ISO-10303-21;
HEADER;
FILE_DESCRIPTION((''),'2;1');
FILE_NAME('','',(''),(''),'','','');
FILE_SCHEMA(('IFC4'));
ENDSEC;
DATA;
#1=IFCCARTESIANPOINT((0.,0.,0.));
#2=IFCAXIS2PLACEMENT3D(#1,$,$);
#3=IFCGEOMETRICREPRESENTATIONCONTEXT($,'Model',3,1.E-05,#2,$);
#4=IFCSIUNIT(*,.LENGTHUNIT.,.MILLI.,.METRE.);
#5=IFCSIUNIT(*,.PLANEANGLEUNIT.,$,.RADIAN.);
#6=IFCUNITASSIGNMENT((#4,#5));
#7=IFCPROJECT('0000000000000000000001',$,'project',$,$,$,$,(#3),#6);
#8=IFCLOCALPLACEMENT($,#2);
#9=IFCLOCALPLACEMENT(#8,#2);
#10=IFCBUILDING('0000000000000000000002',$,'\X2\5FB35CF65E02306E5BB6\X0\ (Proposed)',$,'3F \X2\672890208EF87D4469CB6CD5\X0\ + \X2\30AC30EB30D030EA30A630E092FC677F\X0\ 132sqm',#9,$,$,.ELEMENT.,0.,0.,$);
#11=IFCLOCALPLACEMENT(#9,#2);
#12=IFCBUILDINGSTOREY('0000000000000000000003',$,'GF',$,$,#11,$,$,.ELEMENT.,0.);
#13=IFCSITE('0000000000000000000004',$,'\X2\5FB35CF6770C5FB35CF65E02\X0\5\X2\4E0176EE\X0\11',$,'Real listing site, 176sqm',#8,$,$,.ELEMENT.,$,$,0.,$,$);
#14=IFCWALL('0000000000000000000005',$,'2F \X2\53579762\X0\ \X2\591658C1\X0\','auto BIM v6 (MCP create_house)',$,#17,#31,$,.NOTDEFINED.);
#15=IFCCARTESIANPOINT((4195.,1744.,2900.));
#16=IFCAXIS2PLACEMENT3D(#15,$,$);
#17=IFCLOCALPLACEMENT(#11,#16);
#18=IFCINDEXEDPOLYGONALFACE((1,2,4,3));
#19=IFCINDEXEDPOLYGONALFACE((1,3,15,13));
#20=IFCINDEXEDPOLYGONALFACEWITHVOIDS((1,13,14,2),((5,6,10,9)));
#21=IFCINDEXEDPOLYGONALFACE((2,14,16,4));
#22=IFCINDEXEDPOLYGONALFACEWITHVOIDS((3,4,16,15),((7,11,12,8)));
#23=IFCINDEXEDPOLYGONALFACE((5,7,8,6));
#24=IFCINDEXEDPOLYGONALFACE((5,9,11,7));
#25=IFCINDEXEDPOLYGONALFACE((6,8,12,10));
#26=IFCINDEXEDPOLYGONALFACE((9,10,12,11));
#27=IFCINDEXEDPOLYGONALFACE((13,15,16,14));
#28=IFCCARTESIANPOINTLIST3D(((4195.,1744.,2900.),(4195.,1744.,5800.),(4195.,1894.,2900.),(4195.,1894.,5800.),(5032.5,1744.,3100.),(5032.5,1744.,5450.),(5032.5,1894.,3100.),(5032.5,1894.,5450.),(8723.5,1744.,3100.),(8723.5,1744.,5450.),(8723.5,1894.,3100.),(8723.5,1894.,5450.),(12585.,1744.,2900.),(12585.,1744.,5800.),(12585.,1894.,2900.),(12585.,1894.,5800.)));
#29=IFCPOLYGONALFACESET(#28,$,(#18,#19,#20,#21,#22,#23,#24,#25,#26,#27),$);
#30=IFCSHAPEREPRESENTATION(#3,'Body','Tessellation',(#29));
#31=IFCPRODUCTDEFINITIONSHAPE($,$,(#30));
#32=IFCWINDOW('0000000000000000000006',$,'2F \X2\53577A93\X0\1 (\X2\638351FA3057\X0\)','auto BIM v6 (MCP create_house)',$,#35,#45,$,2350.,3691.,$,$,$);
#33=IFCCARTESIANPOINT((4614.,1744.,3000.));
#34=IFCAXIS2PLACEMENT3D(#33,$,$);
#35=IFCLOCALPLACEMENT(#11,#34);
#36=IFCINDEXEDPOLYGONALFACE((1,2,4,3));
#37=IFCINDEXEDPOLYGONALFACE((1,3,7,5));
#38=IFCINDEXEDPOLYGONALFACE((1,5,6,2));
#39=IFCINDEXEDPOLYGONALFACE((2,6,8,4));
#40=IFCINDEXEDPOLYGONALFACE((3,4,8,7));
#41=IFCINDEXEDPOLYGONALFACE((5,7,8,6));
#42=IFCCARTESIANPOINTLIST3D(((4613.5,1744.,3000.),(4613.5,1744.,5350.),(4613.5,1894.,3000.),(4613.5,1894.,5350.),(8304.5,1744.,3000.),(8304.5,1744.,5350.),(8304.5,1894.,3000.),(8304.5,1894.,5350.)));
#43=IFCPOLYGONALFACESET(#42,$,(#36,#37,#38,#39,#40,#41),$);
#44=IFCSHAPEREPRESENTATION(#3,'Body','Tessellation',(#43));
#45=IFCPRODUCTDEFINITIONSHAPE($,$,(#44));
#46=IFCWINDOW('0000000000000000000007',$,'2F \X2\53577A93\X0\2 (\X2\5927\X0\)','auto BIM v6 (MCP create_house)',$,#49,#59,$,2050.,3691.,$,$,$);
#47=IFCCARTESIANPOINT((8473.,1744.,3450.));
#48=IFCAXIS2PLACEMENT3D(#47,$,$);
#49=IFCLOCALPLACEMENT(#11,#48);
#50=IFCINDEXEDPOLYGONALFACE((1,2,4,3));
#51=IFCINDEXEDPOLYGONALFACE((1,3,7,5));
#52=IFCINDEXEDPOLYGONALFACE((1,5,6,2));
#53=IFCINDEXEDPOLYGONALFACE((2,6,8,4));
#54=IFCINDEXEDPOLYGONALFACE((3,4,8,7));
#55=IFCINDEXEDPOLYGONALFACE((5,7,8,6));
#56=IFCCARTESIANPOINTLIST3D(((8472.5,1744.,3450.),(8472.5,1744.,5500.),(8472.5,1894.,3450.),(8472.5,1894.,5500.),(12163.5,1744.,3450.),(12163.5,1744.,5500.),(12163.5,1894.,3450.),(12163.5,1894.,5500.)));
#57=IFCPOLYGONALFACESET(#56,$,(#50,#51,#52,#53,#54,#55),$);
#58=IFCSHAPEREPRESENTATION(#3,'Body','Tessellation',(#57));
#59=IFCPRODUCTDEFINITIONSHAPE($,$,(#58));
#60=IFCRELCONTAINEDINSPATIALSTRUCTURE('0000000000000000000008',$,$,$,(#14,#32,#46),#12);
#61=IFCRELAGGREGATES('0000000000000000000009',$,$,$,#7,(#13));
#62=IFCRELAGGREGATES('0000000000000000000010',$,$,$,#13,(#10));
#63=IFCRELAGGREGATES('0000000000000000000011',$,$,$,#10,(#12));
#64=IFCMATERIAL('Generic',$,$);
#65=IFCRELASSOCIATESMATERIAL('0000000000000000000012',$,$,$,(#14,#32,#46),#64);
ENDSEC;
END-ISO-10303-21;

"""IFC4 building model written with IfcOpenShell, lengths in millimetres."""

from ifc_helpers import new_model, si_unit, frame, frame_2d, origin, place, context, project, spatial, rectangle, extrude, material, element, fill, save


model = new_model("IFC4")

# Units and contexts
model_context = context("Model", 3, precision=1e-05, world=origin())
ifc_project = project(units=[si_unit("LENGTHUNIT", "METRE", prefix="MILLI"), si_unit("PLANEANGLEUNIT", "RADIAN")], contexts=[model_context])

# Site, building, storey
site_placement = place(None, origin())
site = spatial("IfcSite", under=ifc_project, at=site_placement, Name="徳島県徳島市5丁目11", ObjectType="Real listing site, 176sqm", CompositionType="ELEMENT", RefElevation=0.0)
building_placement = place(site_placement, origin())
building = spatial("IfcBuilding", under=site, at=building_placement, Name="徳島市の家 (Proposed)", ObjectType="3F 木造軸組構法 + ガルバリウム鋼板 132sqm", CompositionType="ELEMENT", ElevationOfRefHeight=0.0, ElevationOfTerrain=0.0)
storey_placement = place(building_placement, origin())
storey = spatial("IfcBuildingStorey", under=building, at=storey_placement, Name="GF", CompositionType="ELEMENT", Elevation=0.0)

# Shared definitions
ifc_material = material(Name="Generic")

# Wall, openings, windows
wall_1_placement = place(storey_placement, frame((4195.0, 1744.0, 2900.0)))
wall_1 = element("IfcWall", 1, at=wall_1_placement, inside=storey, material=ifc_material, Name="2F 南面 外壁", Description="auto BIM v6 (MCP create_house)", PredefinedType="NOTDEFINED", context=model_context, shape_type="SweptSolid", body=[
    extrude(rectangle(XDim=8390.0, YDim=150.0, at=frame_2d((4195.0, 75.0))), frame((4195.0, 1744.0, 2900.0)), (0.0, 0.0, 1.0), 2900.0),
])
opening_1_placement = place(storey_placement, frame((4614.0, 1744.0, 3000.0)))
opening_1 = element("IfcOpeningElement", 2, at=opening_1_placement, cuts=wall_1, PredefinedType="NOTDEFINED", context=model_context, shape_type="SweptSolid", body=[
    extrude(rectangle(XDim=3691.0, YDim=150.0, at=frame_2d((1845.0, 75.0))), frame((4614.0, 1744.0, 3000.0)), (0.0, 0.0, 1.0), 2350.0),
])
opening_2_placement = place(storey_placement, frame((8473.0, 1744.0, 3450.0)))
opening_2 = element("IfcOpeningElement", 3, at=opening_2_placement, cuts=wall_1, PredefinedType="NOTDEFINED", context=model_context, shape_type="SweptSolid", body=[
    extrude(rectangle(XDim=3691.0, YDim=150.0, at=frame_2d((1845.0, 75.0))), frame((8473.0, 1744.0, 3450.0)), (0.0, 0.0, 1.0), 2050.0),
])
window_1_placement = place(storey_placement, frame((4614.0, 1744.0, 3000.0)))
window_1 = element("IfcWindow", 4, at=window_1_placement, inside=storey, material=ifc_material, Name="2F 南窓1 (掃出し)", Description="auto BIM v6 (MCP create_house)", OverallHeight=2350.0, OverallWidth=3691.0, context=model_context, shape_type="SweptSolid", body=[
    extrude(rectangle(XDim=3691.0, YDim=150.0, at=frame_2d((1845.0, 75.0))), frame((4614.0, 1744.0, 3000.0)), (0.0, 0.0, 1.0), 2350.0),
])
fill(opening_1, window_1)
window_2_placement = place(storey_placement, frame((8473.0, 1744.0, 3450.0)))
window_2 = element("IfcWindow", 5, at=window_2_placement, inside=storey, material=ifc_material, Name="2F 南窓2 (大)", Description="auto BIM v6 (MCP create_house)", OverallHeight=2050.0, OverallWidth=3691.0, context=model_context, shape_type="SweptSolid", body=[
    extrude(rectangle(XDim=3691.0, YDim=150.0, at=frame_2d((1845.0, 75.0))), frame((8473.0, 1744.0, 3450.0)), (0.0, 0.0, 1.0), 2050.0),
])
fill(opening_2, window_2)

save(model, "model.ifc")
